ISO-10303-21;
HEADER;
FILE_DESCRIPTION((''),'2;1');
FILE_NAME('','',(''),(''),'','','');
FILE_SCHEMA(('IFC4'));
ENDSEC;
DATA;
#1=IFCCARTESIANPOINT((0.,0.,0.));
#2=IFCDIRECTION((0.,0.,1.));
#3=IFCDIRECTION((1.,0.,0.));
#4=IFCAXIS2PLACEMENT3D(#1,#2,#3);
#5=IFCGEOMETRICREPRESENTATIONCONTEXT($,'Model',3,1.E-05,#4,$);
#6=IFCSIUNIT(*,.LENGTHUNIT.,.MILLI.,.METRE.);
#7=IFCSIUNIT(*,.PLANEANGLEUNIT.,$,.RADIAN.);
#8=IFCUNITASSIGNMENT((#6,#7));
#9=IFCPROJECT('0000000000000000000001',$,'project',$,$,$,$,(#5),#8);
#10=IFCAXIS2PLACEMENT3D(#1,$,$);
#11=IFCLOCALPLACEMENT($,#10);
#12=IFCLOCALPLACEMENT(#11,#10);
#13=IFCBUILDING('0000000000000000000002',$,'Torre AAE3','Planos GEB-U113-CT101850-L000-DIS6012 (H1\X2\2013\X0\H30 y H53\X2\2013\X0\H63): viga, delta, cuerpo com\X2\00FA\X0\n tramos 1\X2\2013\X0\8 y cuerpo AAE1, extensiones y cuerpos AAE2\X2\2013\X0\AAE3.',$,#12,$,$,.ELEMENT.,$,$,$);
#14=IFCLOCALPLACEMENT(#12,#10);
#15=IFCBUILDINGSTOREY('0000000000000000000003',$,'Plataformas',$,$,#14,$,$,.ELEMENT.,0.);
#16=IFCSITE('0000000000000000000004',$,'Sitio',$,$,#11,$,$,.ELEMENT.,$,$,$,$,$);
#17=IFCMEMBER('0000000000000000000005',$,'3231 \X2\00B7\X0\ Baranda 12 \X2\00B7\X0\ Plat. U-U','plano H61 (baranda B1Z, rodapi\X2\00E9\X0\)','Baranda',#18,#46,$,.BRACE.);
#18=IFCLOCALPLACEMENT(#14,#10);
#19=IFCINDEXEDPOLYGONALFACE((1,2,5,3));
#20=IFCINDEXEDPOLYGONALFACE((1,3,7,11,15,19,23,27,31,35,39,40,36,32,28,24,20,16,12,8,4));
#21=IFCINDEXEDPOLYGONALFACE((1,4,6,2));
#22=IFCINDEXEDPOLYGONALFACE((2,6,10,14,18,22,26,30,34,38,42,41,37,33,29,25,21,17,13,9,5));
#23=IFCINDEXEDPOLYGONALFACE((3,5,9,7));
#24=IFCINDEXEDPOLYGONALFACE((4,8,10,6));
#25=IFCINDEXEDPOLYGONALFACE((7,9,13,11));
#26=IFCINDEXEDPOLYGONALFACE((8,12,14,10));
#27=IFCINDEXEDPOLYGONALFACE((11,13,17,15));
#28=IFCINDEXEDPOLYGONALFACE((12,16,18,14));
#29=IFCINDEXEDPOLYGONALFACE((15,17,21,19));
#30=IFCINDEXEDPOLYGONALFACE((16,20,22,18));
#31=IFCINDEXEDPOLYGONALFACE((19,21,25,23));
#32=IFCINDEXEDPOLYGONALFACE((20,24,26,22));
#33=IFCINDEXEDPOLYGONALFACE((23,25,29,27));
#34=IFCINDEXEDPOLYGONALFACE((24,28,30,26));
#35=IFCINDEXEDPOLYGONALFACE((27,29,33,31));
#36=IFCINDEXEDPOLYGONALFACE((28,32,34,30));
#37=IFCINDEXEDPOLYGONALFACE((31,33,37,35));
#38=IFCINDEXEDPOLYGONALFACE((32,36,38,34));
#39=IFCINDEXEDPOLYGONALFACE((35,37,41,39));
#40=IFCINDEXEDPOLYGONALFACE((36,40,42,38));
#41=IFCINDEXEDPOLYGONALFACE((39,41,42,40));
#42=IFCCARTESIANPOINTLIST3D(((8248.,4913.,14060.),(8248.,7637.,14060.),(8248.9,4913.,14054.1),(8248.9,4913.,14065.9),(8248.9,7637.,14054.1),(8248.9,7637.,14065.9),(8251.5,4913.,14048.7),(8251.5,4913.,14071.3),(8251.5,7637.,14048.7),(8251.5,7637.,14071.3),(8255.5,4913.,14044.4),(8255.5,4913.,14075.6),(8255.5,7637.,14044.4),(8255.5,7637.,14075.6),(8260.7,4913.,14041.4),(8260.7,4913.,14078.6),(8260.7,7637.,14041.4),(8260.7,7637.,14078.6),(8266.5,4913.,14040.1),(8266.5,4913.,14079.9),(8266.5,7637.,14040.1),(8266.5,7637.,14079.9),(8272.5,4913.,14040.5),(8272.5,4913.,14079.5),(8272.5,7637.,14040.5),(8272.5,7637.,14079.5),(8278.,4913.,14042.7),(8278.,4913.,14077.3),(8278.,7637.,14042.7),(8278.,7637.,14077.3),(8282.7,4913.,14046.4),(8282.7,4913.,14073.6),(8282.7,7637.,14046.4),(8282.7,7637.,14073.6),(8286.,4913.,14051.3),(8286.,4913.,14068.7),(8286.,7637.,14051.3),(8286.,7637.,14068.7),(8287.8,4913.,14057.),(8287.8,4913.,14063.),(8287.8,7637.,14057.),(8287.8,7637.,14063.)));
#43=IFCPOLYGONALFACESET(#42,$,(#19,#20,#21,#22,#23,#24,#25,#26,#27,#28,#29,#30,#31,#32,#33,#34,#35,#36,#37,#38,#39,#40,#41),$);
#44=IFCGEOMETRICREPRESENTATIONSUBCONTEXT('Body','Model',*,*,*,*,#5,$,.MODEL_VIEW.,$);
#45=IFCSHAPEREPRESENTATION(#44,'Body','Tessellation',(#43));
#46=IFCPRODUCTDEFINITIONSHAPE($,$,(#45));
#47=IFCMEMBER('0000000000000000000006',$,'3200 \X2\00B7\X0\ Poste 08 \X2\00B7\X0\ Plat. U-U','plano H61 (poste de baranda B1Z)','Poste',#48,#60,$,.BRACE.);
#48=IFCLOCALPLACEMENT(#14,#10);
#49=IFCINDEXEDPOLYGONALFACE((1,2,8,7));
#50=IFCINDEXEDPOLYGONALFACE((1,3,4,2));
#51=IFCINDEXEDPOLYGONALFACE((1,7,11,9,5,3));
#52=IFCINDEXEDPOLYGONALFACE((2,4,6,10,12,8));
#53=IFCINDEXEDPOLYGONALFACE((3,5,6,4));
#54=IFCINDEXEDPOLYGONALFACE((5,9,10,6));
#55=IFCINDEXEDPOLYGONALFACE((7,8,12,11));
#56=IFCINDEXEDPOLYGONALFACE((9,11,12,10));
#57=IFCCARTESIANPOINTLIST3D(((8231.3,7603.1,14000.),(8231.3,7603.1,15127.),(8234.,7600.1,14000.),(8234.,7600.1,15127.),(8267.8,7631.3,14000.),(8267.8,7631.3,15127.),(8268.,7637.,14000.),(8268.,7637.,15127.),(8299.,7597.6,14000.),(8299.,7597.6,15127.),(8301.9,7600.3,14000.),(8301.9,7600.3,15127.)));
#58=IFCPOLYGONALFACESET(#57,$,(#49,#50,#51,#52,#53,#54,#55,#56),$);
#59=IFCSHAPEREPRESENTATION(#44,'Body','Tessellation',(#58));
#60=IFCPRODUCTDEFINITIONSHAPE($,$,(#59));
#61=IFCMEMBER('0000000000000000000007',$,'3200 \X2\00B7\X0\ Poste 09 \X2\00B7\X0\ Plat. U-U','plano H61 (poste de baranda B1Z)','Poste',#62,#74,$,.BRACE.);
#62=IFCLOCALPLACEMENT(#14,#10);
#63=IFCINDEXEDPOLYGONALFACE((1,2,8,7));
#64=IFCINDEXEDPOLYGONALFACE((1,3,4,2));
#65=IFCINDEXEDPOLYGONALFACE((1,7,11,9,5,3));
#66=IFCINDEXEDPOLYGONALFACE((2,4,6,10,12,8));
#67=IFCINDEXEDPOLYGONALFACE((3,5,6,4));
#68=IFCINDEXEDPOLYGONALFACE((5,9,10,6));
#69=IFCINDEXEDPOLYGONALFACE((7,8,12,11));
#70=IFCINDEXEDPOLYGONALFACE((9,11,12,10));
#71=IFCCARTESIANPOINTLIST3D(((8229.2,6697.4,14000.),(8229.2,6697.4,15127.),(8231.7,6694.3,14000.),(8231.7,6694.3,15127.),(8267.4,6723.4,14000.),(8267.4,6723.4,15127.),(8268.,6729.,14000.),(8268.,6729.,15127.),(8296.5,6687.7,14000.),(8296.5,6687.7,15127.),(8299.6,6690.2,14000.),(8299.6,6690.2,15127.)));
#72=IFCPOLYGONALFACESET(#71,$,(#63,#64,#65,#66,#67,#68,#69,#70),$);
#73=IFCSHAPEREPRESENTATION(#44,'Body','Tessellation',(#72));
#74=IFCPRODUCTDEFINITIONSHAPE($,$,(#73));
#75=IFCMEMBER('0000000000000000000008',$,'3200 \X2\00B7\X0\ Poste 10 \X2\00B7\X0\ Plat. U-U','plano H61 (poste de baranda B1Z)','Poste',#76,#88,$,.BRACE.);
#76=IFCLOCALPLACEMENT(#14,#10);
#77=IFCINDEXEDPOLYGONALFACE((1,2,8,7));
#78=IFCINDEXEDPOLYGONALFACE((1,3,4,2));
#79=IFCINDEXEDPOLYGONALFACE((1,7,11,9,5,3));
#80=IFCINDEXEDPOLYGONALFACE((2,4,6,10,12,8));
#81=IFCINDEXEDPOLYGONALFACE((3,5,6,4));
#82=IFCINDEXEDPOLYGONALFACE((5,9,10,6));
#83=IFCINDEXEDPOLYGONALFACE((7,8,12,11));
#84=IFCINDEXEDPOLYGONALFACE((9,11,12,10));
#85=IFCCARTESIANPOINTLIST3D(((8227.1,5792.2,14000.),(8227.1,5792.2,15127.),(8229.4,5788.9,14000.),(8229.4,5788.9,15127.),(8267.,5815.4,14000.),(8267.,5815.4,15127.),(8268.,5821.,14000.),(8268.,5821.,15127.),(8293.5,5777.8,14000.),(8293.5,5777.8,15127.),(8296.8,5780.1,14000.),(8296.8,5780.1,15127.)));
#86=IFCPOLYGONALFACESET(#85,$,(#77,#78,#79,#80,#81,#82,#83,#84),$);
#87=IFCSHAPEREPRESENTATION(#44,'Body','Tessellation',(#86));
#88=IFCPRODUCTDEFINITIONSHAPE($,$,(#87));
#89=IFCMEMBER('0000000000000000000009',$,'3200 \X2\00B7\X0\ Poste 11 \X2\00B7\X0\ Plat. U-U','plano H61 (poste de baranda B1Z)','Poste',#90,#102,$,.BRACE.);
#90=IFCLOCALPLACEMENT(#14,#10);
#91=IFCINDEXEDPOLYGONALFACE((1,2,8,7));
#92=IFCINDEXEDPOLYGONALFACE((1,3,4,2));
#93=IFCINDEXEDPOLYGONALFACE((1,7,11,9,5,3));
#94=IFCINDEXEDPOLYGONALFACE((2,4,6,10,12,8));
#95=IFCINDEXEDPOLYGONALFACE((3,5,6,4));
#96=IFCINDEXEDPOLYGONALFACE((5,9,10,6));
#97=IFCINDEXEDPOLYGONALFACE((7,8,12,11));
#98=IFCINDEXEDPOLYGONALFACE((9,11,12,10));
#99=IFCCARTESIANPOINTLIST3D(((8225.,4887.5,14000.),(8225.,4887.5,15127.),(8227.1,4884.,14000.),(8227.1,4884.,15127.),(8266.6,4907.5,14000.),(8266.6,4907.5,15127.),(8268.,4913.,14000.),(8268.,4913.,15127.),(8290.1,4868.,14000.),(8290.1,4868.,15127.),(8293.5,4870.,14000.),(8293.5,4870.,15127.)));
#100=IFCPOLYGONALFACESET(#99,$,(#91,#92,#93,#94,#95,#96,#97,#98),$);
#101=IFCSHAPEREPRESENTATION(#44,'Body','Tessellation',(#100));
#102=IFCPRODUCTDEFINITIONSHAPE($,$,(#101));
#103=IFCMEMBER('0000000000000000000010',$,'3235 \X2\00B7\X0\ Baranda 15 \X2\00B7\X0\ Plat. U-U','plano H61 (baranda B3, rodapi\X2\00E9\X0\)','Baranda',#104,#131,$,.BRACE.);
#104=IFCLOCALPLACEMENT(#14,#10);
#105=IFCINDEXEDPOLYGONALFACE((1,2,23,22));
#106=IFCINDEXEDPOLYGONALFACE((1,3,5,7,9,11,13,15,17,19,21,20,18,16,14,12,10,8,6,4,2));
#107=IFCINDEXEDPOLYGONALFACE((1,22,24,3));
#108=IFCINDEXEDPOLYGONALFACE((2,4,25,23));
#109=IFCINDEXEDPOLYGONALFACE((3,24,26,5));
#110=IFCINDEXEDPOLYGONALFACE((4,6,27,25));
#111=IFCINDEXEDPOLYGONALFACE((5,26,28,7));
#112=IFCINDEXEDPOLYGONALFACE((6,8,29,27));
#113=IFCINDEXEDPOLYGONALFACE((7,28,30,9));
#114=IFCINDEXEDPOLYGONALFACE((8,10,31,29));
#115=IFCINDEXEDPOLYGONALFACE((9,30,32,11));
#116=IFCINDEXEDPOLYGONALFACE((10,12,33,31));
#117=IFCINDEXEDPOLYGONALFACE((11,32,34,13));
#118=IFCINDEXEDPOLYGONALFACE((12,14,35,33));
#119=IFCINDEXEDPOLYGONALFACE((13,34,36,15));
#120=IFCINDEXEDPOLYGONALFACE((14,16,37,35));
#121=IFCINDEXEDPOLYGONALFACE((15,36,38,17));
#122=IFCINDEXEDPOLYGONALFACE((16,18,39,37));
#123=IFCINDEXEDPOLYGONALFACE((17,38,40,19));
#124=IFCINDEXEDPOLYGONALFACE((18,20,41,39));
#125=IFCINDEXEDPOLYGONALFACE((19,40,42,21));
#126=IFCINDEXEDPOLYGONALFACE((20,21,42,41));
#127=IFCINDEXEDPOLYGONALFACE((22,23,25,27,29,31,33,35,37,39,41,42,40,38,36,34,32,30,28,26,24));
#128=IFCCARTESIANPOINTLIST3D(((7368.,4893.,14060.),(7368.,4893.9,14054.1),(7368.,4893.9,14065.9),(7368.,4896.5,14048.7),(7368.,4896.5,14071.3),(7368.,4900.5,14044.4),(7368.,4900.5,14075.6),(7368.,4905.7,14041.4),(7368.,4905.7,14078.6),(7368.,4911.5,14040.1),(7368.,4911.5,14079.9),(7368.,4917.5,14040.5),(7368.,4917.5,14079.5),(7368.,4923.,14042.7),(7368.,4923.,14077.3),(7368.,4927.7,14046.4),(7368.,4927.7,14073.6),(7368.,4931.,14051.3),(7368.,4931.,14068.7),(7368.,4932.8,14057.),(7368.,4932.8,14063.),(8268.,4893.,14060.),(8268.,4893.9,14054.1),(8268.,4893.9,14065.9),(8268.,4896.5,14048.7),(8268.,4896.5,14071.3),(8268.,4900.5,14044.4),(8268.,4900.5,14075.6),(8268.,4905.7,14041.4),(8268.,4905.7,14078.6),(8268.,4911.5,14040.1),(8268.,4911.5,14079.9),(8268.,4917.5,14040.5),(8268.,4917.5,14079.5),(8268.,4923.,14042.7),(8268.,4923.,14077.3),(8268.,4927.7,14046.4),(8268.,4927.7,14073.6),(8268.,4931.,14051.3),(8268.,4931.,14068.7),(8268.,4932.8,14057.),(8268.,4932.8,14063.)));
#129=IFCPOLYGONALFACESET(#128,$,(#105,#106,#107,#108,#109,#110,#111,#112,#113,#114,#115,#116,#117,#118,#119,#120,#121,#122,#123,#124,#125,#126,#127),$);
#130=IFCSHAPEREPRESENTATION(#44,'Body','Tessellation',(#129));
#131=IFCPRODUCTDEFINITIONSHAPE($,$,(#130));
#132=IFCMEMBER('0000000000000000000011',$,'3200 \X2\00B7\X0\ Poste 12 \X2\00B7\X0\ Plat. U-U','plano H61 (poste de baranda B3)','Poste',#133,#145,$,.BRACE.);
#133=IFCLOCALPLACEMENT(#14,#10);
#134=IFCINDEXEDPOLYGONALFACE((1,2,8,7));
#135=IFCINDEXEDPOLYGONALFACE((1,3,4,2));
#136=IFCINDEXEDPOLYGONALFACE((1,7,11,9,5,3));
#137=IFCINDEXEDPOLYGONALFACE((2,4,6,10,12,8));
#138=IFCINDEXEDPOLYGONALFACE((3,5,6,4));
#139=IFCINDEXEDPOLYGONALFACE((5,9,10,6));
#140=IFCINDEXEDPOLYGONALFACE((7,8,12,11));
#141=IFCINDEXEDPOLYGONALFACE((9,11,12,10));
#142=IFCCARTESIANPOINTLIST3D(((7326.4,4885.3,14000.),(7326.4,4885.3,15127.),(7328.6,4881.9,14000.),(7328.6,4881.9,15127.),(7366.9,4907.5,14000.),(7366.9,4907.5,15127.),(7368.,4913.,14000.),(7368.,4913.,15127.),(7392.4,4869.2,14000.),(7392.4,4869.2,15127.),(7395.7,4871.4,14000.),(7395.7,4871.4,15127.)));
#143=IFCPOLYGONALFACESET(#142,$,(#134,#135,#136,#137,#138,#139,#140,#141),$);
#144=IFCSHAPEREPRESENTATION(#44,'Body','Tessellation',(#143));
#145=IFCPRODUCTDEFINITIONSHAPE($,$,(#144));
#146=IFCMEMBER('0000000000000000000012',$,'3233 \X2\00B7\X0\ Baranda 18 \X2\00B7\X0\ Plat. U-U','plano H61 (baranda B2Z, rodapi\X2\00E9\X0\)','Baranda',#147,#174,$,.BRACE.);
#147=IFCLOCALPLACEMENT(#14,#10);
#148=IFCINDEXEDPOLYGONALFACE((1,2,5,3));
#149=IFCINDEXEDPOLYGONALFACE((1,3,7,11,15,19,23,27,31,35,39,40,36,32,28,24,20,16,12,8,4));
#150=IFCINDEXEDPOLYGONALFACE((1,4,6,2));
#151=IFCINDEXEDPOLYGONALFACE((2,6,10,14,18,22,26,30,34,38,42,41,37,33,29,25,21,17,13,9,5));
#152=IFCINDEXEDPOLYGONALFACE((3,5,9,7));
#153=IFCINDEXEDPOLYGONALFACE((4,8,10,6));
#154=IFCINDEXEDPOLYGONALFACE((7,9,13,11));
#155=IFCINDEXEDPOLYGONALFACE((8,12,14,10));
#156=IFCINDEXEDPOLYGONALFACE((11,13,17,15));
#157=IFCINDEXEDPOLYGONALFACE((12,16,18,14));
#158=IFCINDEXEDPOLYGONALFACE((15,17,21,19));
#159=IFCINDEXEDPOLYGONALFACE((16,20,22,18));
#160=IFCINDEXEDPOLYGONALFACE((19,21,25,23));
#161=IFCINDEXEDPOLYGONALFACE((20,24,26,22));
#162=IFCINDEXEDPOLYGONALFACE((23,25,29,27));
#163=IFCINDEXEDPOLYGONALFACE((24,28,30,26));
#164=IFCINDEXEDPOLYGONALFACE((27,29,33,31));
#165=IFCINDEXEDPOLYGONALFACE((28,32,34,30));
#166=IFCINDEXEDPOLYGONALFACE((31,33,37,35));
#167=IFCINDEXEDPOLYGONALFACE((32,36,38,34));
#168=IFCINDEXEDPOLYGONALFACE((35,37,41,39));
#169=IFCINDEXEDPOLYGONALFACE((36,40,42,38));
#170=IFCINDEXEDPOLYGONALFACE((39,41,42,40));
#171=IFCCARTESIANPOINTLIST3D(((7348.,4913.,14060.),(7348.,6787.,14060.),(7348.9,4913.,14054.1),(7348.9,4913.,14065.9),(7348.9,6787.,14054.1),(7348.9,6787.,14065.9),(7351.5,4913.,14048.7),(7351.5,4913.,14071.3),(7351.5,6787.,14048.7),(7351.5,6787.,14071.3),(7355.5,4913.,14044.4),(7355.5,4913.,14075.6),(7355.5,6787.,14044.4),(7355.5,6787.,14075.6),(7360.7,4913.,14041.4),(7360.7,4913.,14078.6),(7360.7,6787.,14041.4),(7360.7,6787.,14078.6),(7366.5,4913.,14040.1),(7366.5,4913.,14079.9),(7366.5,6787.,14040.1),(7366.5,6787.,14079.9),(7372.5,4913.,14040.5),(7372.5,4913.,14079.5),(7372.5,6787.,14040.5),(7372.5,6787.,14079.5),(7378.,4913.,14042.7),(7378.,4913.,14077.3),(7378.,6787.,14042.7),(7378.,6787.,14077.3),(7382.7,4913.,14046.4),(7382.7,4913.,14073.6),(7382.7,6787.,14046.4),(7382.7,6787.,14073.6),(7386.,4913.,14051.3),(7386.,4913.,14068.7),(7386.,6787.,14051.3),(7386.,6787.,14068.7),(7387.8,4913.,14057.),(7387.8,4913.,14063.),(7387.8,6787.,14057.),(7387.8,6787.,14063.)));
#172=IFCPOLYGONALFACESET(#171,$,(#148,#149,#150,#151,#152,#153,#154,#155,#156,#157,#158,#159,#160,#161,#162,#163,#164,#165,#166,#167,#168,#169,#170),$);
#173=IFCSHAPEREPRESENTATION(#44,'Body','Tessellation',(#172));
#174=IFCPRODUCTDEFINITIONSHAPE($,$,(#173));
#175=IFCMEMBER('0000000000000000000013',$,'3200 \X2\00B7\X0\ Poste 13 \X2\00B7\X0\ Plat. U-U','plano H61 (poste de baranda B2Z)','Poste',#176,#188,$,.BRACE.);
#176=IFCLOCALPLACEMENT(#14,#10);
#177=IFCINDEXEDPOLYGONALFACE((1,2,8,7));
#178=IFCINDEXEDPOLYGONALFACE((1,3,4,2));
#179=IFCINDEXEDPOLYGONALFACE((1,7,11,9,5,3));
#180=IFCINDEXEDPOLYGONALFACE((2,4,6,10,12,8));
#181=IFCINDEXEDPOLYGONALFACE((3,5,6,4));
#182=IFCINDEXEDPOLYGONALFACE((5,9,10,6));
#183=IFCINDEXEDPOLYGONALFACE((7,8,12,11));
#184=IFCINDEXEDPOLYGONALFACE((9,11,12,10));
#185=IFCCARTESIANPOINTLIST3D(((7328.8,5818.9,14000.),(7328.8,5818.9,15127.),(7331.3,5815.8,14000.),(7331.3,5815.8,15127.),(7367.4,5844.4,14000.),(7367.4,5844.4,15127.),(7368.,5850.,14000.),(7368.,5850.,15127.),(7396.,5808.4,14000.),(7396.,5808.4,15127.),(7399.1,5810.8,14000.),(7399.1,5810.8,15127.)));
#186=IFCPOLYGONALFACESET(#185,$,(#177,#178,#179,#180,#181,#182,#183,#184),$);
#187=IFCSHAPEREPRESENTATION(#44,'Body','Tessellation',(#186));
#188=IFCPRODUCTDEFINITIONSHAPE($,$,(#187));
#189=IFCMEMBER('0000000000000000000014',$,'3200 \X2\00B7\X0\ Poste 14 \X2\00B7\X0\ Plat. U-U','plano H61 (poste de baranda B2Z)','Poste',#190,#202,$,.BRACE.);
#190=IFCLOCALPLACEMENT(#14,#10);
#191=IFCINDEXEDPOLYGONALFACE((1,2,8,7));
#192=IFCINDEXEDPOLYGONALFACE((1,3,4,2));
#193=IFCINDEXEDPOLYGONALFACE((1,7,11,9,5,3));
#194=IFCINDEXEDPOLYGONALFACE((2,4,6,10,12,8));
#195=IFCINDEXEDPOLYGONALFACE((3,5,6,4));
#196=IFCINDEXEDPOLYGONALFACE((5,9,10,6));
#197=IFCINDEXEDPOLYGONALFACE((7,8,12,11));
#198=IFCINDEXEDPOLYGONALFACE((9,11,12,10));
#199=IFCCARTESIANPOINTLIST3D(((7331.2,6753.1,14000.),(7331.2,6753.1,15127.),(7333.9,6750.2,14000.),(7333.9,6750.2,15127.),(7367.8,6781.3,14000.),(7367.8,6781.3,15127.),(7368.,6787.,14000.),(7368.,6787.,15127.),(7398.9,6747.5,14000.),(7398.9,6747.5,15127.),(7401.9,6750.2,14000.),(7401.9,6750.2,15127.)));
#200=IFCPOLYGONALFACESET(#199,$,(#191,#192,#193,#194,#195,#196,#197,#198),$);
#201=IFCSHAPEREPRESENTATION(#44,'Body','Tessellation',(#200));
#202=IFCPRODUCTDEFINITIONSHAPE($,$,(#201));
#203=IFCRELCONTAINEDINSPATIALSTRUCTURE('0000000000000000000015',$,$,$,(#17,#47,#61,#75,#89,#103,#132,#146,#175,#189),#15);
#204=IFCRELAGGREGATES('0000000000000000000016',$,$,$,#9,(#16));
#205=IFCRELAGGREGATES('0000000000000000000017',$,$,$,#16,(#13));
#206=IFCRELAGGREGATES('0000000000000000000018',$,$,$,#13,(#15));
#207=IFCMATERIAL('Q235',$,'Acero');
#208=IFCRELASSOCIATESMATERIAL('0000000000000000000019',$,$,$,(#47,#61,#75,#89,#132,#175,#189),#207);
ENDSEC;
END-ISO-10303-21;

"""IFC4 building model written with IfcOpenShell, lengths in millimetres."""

from ifc_helpers import new_model, si_unit, frame, frame_2d, origin, origin_with_axes, place, context, subcontext, project, spatial, circle, l_section, extrude, material, element, save


model = new_model("IFC4")

# Units and contexts
model_context = context("Model", 3, precision=1e-05, world=origin_with_axes())
body_context = subcontext(model_context, "Body", "Model", "MODEL_VIEW")
ifc_project = project(units=[si_unit("LENGTHUNIT", "METRE", prefix="MILLI"), si_unit("PLANEANGLEUNIT", "RADIAN")], contexts=[model_context])

# Site, building, storey
site_placement = place(None, origin())
site = spatial("IfcSite", under=ifc_project, at=site_placement, Name="Sitio", CompositionType="ELEMENT")
building_placement = place(site_placement, origin())
building = spatial("IfcBuilding", under=site, at=building_placement, Name="Torre AAE3", Description="Planos GEB-U113-CT101850-L000-DIS6012 (H1–H30 y H53–H63): viga, delta, cuerpo común tramos 1–8 y cuerpo AAE1, extensiones y cuerpos AAE2–AAE3.", CompositionType="ELEMENT")
storey_placement = place(building_placement, origin())
storey = spatial("IfcBuildingStorey", under=building, at=storey_placement, Name="Plataformas", CompositionType="ELEMENT", Elevation=0.0)

# Members
ifc_material = material(Name="Q235", Category="Acero")
for number, where, z_axis, x_axis, name in (
    (1, (8268.0, 7637.0, 14060.0), (0.0, -1.0, 0.0), (-1.0, 0.0, 0.0), "3231 · Baranda 12 · Plat. U-U"),
):
    element("IfcMember", number, at=place(storey_placement, frame(where, z_axis=z_axis, x_axis=x_axis)), inside=storey, Name=name, Description="plano H61 (baranda B1Z, rodapié)", ObjectType="Baranda", PredefinedType="BRACE", context=body_context, shape_type="SweptSolid", body=[
        extrude(circle(Radius=20.0), None, (0.0, 0.0, 1.0), 2724.0),
    ])
for number, where, z_axis, x_axis, name in (
    (2, (8268.0, 7637.0, 14000.0), (0.0, 0.0, 1.0), (-0.734582, -0.67852, 0.0), "3200 · Poste 08 · Plat. U-U"),
    (3, (8268.0, 6729.0, 14000.0), (0.0, 0.0, 1.0), (-0.775597, -0.631228, 0.0), "3200 · Poste 09 · Plat. U-U"),
    (4, (8268.0, 5821.0, 14000.0), (0.0, 0.0, 1.0), (-0.817677, -0.575677, 0.0), "3200 · Poste 10 · Plat. U-U"),
    (5, (8268.0, 4913.0, 14000.0), (0.0, 0.0, 1.0), (-0.859678, -0.510837, 0.0), "3200 · Poste 11 · Plat. U-U"),
):
    element("IfcMember", number, at=place(storey_placement, frame(where, z_axis=z_axis, x_axis=x_axis)), inside=storey, material=ifc_material, Name=name, Description="plano H61 (poste de baranda B1Z)", ObjectType="Poste", PredefinedType="BRACE", context=body_context, shape_type="SweptSolid", body=[
        extrude(l_section(Depth=50.0, Width=50.0, Thickness=4.0, at=frame_2d((25.0, 25.0))), None, (0.0, 0.0, 1.0), 1127.0),
    ])
member_1_placement = place(storey_placement, frame((8268.0, 4913.0, 14060.0), z_axis=(-1.0, 0.0, 0.0), x_axis=(0.0, -1.0, 0.0)))
element("IfcMember", 6, at=member_1_placement, inside=storey, Name="3235 · Baranda 15 · Plat. U-U", Description="plano H61 (baranda B3, rodapié)", ObjectType="Baranda", PredefinedType="BRACE", context=body_context, shape_type="SweptSolid", body=[
    extrude(circle(Radius=20.0), None, (0.0, 0.0, 1.0), 900.0),
])
member_2_placement = place(storey_placement, frame((7368.0, 4913.0, 14000.0), z_axis=(0.0, 0.0, 1.0), x_axis=(-0.831998, -0.554778, 0.0)))
element("IfcMember", 7, at=member_2_placement, inside=storey, material=ifc_material, Name="3200 · Poste 12 · Plat. U-U", Description="plano H61 (poste de baranda B3)", ObjectType="Poste", PredefinedType="BRACE", context=body_context, shape_type="SweptSolid", body=[
    extrude(l_section(Depth=50.0, Width=50.0, Thickness=4.0, at=frame_2d((25.0, 25.0))), None, (0.0, 0.0, 1.0), 1127.0),
])
member_3_placement = place(storey_placement, frame((7368.0, 4913.0, 14060.0), z_axis=(0.0, 1.0, 0.0), x_axis=(-1.0, 0.0, 0.0)))
element("IfcMember", 8, at=member_3_placement, inside=storey, Name="3233 · Baranda 18 · Plat. U-U", Description="plano H61 (baranda B2Z, rodapié)", ObjectType="Baranda", PredefinedType="BRACE", context=body_context, shape_type="SweptSolid", body=[
    extrude(circle(Radius=20.0), None, (0.0, 0.0, 1.0), 1874.0),
])
for number, where, z_axis, x_axis, name in (
    (9, (7368.0, 5850.0, 14000.0), (0.0, 0.0, 1.0), (-0.783166, -0.621813, 0.0), "3200 · Poste 13 · Plat. U-U"),
    (10, (7368.0, 6787.0, 14000.0), (0.0, 0.0, 1.0), (-0.735511, -0.677513, 0.0), "3200 · Poste 14 · Plat. U-U"),
):
    element("IfcMember", number, at=place(storey_placement, frame(where, z_axis=z_axis, x_axis=x_axis)), inside=storey, material=ifc_material, Name=name, Description="plano H61 (poste de baranda B2Z)", ObjectType="Poste", PredefinedType="BRACE", context=body_context, shape_type="SweptSolid", body=[
        extrude(l_section(Depth=50.0, Width=50.0, Thickness=4.0, at=frame_2d((25.0, 25.0))), None, (0.0, 0.0, 1.0), 1127.0),
    ])

save(model, "model.ifc")
